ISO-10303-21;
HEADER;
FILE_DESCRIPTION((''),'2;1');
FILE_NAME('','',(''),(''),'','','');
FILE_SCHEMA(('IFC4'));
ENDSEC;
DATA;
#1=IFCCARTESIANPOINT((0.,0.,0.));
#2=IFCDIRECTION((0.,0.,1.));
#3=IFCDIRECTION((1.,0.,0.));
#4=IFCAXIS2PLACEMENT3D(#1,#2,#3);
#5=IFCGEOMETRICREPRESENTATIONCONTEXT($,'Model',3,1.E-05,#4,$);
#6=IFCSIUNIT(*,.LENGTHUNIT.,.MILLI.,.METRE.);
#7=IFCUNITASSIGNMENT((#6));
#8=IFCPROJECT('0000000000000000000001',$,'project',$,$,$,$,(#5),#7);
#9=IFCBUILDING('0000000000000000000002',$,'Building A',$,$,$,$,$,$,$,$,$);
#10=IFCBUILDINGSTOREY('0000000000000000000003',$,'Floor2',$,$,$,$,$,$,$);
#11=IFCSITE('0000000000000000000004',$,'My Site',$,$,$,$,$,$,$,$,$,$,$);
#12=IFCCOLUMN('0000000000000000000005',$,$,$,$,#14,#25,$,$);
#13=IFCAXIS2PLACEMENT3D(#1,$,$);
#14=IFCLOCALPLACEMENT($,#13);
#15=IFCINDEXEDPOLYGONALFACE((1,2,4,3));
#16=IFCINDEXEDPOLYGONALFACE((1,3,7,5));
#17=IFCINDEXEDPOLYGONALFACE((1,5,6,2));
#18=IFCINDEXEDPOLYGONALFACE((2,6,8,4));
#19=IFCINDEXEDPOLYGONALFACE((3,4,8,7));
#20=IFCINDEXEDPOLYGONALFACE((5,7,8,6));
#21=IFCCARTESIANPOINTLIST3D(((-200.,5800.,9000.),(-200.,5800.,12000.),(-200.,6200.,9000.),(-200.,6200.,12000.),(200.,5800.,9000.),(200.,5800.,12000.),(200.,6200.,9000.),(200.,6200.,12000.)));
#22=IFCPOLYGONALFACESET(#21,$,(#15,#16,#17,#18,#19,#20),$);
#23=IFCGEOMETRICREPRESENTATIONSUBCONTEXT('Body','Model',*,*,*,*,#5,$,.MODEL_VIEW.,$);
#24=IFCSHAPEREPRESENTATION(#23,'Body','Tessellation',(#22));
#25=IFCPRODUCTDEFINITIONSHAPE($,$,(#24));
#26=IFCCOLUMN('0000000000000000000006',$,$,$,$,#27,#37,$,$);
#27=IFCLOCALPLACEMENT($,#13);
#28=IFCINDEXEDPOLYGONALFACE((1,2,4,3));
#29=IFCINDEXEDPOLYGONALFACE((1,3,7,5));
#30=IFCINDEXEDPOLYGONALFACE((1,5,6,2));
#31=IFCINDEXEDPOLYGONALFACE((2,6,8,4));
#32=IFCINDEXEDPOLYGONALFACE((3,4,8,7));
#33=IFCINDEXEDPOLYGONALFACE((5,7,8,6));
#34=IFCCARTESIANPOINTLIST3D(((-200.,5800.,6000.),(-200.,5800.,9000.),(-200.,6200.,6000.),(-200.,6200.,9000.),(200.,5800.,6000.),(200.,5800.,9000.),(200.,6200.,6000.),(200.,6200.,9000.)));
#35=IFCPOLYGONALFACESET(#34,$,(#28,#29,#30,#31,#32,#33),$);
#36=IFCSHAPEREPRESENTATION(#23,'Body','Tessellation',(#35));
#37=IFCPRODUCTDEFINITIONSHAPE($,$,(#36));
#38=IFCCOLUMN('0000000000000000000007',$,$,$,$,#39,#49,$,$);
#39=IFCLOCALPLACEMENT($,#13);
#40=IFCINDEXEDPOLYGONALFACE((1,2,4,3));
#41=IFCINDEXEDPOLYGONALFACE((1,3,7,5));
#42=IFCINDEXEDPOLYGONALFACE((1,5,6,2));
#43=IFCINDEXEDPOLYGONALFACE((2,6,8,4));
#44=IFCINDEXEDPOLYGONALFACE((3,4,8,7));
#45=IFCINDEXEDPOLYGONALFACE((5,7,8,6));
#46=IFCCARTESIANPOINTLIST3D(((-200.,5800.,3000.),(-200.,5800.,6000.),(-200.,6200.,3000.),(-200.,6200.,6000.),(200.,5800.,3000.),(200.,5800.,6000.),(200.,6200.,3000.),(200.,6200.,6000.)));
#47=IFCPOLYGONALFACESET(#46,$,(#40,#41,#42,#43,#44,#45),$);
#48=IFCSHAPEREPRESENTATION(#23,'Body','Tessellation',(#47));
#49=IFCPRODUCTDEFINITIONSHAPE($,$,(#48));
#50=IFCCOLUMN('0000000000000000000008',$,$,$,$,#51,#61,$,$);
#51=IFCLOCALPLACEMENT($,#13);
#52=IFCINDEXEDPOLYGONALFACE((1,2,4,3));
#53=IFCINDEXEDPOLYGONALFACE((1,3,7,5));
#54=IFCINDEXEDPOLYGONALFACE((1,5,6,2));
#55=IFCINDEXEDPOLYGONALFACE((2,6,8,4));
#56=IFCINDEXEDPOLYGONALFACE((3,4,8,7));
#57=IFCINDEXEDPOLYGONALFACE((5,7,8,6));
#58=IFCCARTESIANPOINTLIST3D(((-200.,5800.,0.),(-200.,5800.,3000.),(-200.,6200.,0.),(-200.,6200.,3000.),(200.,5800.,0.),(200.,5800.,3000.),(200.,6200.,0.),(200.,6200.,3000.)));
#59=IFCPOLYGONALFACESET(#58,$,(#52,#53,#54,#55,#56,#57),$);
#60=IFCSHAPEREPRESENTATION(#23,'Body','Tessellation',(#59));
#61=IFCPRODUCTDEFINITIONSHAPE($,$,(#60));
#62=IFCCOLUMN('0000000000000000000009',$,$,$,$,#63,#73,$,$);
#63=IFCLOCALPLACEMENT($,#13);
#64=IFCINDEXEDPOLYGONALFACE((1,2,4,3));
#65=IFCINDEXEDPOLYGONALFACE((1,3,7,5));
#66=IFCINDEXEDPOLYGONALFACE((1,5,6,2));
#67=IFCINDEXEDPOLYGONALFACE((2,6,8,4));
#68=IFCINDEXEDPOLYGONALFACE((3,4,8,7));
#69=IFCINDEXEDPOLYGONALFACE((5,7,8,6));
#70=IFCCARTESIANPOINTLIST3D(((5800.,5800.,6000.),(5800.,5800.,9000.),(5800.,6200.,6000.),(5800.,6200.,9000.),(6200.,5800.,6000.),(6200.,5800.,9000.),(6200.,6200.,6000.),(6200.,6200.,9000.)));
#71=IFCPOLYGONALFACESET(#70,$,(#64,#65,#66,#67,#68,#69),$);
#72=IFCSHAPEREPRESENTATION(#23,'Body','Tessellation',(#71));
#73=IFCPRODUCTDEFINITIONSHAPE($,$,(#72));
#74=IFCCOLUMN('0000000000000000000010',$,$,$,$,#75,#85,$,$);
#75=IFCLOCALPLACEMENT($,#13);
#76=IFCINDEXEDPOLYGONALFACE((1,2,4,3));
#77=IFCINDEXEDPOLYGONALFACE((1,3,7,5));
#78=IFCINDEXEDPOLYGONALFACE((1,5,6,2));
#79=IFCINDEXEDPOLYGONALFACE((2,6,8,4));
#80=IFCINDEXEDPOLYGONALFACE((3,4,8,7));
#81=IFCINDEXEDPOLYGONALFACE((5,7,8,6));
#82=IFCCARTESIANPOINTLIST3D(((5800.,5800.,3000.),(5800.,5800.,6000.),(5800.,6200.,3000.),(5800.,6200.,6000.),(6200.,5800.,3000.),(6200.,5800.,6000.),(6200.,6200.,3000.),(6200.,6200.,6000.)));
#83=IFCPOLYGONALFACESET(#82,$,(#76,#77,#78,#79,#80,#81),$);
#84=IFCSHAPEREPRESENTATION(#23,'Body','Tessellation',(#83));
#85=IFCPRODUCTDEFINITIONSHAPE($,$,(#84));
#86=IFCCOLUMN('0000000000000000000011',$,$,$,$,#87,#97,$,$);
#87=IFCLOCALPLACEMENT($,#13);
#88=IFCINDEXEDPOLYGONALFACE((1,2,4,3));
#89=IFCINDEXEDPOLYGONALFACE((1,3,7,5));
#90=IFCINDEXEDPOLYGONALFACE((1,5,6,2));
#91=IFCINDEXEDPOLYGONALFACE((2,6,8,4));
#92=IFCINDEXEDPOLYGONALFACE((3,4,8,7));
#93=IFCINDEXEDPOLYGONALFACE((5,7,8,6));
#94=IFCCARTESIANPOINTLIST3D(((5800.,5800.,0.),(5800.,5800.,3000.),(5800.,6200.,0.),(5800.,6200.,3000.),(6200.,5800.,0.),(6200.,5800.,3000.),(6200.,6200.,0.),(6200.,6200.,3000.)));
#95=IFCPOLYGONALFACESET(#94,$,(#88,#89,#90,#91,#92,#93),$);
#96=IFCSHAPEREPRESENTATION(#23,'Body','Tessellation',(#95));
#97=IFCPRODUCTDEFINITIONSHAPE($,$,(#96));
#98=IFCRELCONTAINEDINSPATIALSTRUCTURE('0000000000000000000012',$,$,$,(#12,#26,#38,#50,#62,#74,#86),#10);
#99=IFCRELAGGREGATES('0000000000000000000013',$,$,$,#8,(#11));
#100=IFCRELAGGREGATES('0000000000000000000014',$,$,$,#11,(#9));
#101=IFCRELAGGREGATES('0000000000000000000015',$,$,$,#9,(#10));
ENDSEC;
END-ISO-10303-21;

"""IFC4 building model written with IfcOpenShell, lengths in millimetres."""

from ifc_helpers import new_model, si_unit, frame, origin_with_axes, place, context, subcontext, project, spatial, line, indexed_curve, outline, extrude, element, save


model = new_model("IFC4")

# Units and contexts
model_context = context("Model", 3, precision=1e-05, world=origin_with_axes())
body_context = subcontext(model_context, "Body", "Model", "MODEL_VIEW")
ifc_project = project(units=[si_unit("LENGTHUNIT", "METRE", prefix="MILLI")], contexts=[model_context])

# Site, building, storey
site = spatial("IfcSite", under=ifc_project, Name="My Site")
building = spatial("IfcBuilding", under=site, Name="Building A")
storey = spatial("IfcBuildingStorey", under=building, Name="Floor2")

# Columns
for number, where, z_axis, x_axis in (
    (1, (0.0, 6000.0, 9000.0), (0.0, 0.0, 1.0), (1.0, 0.0, 0.0)),
    (2, (0.0, 6000.0, 6000.0), (0.0, 0.0, 1.0), (1.0, 0.0, 0.0)),
    (3, (0.0, 6000.0, 3000.0), (0.0, 0.0, 1.0), (1.0, 0.0, 0.0)),
    (4, (0.0, 6000.0, 0.0), (0.0, 0.0, 1.0), (1.0, 0.0, 0.0)),
    (5, (6000.0, 6000.0, 6000.0), (0.0, 0.0, 1.0), (1.0, 0.0, 0.0)),
    (6, (6000.0, 6000.0, 3000.0), (0.0, 0.0, 1.0), (1.0, 0.0, 0.0)),
    (7, (6000.0, 6000.0, 0.0), (0.0, 0.0, 1.0), (1.0, 0.0, 0.0)),
):
    element("IfcColumn", number, at=place(None, frame(where, z_axis=z_axis, x_axis=x_axis)), inside=storey, context=body_context, shape_type="SweptSolid", body=[
        extrude(outline(indexed_curve([(-200.0, -200.0), (200.0, -200.0), (200.0, 200.0), (-200.0, 200.0)], segments=[line(1, 2, 3, 4, 1)])), origin_with_axes(), (0.0, 0.0, 1.0), 3000.0),
    ])

save(model, "model.ifc")
